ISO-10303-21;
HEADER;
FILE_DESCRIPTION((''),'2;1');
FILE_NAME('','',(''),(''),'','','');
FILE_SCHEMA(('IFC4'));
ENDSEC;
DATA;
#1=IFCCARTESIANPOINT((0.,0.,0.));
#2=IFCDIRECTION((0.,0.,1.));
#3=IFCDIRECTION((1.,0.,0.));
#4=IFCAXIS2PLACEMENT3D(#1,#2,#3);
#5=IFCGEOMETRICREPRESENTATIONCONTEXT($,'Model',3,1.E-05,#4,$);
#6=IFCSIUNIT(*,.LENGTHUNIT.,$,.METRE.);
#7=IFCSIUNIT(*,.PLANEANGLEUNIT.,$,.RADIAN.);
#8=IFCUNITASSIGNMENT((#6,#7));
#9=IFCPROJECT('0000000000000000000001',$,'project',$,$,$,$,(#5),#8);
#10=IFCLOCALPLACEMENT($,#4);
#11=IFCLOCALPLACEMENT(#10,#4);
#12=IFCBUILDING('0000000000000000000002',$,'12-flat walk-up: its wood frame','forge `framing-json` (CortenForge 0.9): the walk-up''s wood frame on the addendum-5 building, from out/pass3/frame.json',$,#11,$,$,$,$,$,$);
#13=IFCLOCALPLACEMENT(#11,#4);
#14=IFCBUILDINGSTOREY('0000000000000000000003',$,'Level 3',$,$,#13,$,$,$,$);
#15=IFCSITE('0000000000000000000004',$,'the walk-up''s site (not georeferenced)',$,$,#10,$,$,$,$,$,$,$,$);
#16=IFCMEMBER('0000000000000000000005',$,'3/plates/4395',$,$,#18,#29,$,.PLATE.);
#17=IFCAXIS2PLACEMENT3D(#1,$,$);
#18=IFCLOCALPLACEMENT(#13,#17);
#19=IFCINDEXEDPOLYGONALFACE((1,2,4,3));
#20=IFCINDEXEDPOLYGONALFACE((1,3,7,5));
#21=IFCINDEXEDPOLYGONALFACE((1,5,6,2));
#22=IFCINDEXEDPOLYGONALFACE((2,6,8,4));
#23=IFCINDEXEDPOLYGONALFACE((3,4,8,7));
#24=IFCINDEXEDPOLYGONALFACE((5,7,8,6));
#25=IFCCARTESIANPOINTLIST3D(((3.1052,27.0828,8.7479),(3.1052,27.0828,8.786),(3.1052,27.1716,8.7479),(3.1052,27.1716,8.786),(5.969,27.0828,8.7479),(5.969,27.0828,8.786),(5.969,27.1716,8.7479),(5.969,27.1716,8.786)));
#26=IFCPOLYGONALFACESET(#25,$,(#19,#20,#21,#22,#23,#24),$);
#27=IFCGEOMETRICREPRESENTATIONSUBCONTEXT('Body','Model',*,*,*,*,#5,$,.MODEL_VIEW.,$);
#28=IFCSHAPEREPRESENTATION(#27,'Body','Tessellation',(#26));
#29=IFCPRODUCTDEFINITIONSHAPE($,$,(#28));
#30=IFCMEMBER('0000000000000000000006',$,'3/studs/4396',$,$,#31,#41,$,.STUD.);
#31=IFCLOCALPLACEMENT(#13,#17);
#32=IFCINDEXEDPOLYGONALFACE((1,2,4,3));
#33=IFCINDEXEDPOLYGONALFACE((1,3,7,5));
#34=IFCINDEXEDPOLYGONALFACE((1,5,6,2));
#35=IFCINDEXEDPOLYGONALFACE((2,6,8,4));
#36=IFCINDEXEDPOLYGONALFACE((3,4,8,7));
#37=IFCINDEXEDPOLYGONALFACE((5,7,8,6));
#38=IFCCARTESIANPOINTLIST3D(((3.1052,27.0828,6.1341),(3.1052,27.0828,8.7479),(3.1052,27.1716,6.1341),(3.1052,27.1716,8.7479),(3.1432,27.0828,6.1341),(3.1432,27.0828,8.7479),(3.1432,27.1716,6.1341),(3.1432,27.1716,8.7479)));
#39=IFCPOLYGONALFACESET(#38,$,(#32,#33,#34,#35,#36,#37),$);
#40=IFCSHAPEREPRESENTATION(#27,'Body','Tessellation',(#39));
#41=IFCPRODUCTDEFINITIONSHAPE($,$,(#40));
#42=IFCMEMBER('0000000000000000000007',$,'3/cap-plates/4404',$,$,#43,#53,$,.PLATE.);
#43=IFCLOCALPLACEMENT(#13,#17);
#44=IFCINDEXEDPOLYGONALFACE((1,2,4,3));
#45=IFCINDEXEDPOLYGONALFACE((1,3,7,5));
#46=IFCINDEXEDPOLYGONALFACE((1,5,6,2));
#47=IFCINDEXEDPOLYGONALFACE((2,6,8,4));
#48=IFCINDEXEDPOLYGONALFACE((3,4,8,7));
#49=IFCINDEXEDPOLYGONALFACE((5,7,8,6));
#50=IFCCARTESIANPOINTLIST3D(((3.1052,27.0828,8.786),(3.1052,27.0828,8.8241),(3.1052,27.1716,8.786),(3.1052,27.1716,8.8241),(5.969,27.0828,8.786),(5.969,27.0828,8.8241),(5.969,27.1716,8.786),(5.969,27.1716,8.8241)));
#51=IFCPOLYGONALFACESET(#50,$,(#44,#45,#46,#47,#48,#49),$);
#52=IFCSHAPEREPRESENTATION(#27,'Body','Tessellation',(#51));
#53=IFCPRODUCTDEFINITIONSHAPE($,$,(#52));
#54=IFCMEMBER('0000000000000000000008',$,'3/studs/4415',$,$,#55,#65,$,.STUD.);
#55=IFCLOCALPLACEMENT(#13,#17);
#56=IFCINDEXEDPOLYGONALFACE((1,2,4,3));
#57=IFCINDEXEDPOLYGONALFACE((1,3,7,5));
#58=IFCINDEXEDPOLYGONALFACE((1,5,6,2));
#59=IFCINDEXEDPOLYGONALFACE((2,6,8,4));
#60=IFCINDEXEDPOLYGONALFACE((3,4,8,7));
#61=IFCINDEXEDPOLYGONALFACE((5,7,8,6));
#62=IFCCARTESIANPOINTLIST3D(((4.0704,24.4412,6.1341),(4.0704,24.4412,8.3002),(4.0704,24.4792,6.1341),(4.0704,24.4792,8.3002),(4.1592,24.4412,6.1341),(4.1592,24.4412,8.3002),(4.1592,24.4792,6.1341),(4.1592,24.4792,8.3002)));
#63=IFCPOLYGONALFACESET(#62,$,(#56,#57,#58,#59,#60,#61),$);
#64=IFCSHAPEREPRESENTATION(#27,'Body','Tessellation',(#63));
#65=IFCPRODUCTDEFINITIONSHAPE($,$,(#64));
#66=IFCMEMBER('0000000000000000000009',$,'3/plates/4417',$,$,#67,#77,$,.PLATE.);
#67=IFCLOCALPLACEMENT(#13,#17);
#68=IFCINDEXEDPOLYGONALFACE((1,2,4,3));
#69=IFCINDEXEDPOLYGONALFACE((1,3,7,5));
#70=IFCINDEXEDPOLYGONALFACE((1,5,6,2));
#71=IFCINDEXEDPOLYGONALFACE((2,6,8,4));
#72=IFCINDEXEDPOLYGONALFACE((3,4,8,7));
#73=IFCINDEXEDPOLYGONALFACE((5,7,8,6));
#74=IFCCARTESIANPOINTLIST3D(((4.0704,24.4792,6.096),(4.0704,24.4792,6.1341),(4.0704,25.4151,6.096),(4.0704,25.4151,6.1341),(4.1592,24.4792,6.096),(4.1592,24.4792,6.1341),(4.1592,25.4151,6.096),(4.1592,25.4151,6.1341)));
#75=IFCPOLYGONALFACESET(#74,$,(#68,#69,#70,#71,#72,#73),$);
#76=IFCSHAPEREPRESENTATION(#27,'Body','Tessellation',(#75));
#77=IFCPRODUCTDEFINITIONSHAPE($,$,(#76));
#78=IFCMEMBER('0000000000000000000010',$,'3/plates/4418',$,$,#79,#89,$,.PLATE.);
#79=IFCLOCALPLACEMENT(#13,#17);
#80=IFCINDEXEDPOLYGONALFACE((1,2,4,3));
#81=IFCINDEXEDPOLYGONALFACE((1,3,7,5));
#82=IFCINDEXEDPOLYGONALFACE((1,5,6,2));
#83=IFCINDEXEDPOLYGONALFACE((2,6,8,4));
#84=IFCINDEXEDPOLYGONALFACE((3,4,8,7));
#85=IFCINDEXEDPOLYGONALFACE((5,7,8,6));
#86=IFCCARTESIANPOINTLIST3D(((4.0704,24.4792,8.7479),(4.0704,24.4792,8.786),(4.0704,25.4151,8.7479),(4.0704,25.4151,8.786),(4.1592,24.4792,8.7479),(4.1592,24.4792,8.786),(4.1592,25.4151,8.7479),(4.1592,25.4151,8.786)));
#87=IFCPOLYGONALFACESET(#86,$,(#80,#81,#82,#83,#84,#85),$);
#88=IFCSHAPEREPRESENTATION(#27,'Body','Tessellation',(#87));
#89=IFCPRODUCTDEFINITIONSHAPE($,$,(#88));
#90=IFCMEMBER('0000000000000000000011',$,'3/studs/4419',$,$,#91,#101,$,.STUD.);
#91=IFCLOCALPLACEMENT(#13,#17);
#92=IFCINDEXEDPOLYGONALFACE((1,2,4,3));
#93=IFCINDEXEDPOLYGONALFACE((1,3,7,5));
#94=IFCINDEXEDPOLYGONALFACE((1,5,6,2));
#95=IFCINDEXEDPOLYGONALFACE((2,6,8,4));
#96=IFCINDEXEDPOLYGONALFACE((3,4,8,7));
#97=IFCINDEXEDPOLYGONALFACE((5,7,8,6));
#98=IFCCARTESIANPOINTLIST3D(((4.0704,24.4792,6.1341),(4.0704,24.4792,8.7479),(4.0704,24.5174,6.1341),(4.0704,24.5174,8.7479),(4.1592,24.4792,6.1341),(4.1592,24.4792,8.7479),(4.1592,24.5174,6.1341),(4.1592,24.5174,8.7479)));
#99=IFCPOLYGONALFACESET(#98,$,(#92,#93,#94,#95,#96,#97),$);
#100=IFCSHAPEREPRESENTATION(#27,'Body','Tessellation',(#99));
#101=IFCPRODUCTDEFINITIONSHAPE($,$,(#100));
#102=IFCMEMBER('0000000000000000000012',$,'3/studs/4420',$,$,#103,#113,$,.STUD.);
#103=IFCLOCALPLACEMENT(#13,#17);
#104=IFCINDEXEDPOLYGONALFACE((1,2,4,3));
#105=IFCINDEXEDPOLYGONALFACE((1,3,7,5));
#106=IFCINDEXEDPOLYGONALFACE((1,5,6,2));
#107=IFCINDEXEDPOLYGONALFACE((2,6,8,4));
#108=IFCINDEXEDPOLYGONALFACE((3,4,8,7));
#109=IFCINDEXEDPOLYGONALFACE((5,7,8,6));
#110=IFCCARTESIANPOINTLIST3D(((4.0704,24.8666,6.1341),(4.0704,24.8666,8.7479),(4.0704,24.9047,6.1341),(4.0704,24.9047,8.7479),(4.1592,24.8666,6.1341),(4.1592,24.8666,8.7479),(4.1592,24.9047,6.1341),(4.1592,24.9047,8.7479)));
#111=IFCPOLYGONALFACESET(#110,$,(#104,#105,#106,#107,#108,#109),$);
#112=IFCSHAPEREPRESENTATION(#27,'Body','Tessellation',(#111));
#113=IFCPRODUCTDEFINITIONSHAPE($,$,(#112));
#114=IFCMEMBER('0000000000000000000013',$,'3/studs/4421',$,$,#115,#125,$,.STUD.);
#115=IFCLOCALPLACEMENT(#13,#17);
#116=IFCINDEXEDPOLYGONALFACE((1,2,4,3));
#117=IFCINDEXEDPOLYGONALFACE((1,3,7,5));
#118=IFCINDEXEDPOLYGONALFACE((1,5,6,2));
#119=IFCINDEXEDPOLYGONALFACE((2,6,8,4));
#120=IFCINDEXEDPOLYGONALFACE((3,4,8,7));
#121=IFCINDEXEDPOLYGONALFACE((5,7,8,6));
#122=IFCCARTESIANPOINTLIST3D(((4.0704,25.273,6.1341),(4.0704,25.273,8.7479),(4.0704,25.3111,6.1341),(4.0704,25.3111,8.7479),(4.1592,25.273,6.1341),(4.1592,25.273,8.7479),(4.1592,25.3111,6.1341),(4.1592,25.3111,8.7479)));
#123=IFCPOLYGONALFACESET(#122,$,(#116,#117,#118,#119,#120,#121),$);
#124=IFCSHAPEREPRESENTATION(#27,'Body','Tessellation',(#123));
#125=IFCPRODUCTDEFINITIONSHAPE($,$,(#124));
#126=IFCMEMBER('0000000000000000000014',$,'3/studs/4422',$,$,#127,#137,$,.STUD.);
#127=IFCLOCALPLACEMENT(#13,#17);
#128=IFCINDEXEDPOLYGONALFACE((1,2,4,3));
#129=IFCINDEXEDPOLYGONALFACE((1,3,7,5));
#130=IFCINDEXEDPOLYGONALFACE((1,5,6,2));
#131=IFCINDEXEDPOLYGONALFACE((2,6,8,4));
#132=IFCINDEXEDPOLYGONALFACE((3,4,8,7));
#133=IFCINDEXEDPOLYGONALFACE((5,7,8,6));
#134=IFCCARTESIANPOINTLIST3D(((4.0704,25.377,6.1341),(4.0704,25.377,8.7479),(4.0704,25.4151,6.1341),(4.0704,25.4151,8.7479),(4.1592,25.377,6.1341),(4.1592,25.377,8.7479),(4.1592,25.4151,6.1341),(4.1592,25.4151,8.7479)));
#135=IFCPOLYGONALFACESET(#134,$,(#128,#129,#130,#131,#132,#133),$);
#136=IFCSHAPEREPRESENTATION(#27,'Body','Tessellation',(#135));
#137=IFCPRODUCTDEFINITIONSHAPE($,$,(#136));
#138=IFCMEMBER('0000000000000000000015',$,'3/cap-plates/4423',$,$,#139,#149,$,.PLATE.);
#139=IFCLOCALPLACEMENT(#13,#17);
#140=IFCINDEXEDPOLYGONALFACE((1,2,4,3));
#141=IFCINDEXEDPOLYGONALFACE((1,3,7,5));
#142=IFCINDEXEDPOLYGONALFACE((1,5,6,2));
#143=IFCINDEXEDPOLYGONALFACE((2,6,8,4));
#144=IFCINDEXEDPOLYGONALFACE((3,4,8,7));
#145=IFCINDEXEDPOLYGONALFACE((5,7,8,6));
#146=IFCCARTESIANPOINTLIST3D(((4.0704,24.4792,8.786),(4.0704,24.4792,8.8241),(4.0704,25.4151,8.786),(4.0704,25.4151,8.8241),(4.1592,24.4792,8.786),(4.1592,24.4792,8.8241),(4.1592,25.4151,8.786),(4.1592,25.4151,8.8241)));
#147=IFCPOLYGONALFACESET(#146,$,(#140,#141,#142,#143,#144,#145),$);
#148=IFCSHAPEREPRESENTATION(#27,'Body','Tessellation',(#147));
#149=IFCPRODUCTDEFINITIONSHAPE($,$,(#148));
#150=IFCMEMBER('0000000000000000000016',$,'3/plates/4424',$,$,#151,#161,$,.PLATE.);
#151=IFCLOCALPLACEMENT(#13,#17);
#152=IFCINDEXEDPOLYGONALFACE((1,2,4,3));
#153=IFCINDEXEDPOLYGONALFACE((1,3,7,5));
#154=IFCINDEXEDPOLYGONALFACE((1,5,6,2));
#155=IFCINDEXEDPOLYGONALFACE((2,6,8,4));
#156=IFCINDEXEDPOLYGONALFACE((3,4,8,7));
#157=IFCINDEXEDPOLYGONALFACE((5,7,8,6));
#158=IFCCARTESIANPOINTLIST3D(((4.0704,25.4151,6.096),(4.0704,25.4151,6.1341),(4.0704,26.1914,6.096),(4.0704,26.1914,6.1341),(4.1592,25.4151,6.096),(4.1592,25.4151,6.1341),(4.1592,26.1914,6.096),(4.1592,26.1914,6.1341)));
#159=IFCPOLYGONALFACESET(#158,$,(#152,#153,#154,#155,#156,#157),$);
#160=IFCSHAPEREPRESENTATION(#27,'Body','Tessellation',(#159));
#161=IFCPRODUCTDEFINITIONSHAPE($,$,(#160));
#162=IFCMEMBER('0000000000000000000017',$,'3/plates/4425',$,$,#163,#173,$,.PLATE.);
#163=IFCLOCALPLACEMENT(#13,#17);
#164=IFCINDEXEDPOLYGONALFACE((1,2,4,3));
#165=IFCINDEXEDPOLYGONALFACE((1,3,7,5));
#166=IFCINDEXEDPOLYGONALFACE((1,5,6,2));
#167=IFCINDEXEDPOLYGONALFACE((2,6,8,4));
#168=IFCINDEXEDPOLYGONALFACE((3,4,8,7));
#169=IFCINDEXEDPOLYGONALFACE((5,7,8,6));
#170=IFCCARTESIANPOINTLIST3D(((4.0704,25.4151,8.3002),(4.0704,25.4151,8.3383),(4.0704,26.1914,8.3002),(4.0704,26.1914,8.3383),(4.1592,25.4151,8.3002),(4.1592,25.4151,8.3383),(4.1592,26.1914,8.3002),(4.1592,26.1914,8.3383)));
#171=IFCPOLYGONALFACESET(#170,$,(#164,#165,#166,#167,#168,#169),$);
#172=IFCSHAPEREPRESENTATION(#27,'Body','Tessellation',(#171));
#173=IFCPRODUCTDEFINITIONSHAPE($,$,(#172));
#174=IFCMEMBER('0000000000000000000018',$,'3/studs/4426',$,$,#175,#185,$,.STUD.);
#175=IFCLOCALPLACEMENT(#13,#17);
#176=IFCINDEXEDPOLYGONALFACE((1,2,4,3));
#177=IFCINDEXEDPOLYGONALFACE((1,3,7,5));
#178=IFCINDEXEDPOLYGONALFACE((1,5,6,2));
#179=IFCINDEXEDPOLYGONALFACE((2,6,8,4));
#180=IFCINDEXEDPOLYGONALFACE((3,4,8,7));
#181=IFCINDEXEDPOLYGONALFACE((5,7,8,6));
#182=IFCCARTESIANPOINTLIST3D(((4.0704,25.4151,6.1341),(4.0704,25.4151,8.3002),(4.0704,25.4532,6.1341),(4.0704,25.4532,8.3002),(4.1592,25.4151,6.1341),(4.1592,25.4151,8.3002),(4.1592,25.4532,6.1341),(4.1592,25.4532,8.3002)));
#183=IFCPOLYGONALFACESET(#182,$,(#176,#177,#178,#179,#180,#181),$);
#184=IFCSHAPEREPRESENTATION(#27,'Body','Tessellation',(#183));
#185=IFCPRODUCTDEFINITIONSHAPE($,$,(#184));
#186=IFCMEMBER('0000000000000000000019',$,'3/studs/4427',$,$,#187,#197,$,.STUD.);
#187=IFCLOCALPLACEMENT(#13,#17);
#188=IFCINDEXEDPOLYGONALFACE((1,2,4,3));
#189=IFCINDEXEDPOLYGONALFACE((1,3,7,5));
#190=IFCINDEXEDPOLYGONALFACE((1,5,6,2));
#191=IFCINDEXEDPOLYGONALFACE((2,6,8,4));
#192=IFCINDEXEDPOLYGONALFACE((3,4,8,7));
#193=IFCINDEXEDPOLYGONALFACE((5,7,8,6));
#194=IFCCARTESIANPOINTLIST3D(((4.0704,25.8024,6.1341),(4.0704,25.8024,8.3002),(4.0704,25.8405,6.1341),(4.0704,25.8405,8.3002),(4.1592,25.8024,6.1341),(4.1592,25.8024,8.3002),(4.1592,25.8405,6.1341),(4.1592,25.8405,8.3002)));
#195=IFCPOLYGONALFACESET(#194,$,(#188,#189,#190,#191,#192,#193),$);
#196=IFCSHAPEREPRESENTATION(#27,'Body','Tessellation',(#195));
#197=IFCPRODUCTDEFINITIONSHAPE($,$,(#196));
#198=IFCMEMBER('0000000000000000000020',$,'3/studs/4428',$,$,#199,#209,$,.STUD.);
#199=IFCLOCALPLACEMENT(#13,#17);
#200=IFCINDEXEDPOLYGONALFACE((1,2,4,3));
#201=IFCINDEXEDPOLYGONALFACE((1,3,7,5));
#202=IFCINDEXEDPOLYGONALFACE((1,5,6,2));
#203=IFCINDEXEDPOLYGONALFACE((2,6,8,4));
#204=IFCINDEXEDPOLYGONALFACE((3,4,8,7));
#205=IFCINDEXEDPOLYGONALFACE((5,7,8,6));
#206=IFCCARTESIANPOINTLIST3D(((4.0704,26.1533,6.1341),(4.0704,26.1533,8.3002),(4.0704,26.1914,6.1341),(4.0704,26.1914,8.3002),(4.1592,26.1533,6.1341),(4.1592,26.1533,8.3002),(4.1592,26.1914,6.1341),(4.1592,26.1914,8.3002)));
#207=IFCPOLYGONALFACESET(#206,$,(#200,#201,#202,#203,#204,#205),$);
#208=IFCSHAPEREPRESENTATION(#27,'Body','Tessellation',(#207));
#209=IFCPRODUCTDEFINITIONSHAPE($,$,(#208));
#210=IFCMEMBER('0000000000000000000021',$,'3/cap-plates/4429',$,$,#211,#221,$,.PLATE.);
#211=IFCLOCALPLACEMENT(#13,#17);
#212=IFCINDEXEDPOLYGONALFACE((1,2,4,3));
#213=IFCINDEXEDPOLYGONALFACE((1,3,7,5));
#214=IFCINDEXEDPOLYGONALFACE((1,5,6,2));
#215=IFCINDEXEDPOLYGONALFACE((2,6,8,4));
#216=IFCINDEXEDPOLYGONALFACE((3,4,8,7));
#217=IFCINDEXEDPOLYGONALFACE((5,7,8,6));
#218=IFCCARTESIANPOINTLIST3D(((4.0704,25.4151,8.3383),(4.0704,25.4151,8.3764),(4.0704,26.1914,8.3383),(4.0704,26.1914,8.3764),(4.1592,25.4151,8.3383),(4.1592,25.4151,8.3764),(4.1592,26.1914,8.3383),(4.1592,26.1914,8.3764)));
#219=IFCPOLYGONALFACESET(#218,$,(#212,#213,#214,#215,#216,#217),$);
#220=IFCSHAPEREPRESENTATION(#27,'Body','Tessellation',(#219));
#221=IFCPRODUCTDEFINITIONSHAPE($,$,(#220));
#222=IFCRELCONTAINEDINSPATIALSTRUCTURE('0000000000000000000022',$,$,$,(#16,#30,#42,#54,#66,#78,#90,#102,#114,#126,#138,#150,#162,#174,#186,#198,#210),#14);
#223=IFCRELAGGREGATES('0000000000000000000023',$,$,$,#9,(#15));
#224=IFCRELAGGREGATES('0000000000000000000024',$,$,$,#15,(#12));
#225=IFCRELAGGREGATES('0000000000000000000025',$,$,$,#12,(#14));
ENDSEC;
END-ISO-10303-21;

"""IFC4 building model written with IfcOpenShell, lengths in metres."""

from ifc_helpers import new_model, si_unit, frame, frame_2d, origin, origin_with_axes, place, context, subcontext, project, spatial, rectangle, extrude, element, save


model = new_model("IFC4")

# Units and contexts
model_context = context("Model", 3, precision=1e-05, world=origin_with_axes())
body_context = subcontext(model_context, "Body", "Model", "MODEL_VIEW")
ifc_project = project(units=[si_unit("LENGTHUNIT", "METRE"), si_unit("PLANEANGLEUNIT", "RADIAN")], contexts=[model_context])

# Site, building, storey
site_placement = place(None, origin_with_axes())
site = spatial("IfcSite", under=ifc_project, at=site_placement, Name="the walk-up's site (not georeferenced)")
building_placement = place(site_placement, origin_with_axes())
building = spatial("IfcBuilding", under=site, at=building_placement, Name="12-flat walk-up: its wood frame", Description="forge `framing-json` (CortenForge 0.9): the walk-up's wood frame on the addendum-5 building, from out/pass3/frame.json")
storey_placement = place(building_placement, origin_with_axes())
storey = spatial("IfcBuildingStorey", under=building, at=storey_placement, Name="Level 3")

# Members
member_1_placement = place(storey_placement, frame((3.1052, 27.0828, 8.7479), z_axis=(0.0, 0.0, 1.0), x_axis=(1.0, 0.0, 0.0)))
element("IfcMember", 1, at=member_1_placement, inside=storey, Name="3/plates/4395", PredefinedType="PLATE", context=body_context, shape_type="SweptSolid", body=[
    extrude(rectangle(XDim=2.8639, YDim=0.0889, at=frame_2d((1.4319, 0.0444))), origin(), (0.0, 0.0, 1.0), 0.0381),
])
member_2_placement = place(storey_placement, frame((3.1052, 27.0828, 6.1341), z_axis=(0.0, 0.0, 1.0), x_axis=(1.0, 0.0, 0.0)))
element("IfcMember", 2, at=member_2_placement, inside=storey, Name="3/studs/4396", PredefinedType="STUD", context=body_context, shape_type="SweptSolid", body=[
    extrude(rectangle(XDim=0.0381, YDim=0.0889, at=frame_2d((0.0191, 0.0444))), origin(), (0.0, 0.0, 1.0), 2.6138),
])
member_3_placement = place(storey_placement, frame((3.1052, 27.0828, 8.786), z_axis=(0.0, 0.0, 1.0), x_axis=(1.0, 0.0, 0.0)))
element("IfcMember", 3, at=member_3_placement, inside=storey, Name="3/cap-plates/4404", PredefinedType="PLATE", context=body_context, shape_type="SweptSolid", body=[
    extrude(rectangle(XDim=2.8639, YDim=0.0889, at=frame_2d((1.4319, 0.0444))), origin(), (0.0, 0.0, 1.0), 0.0381),
])
member_4_placement = place(storey_placement, frame((4.0704, 24.4412, 6.1341), z_axis=(0.0, 0.0, 1.0), x_axis=(1.0, 0.0, 0.0)))
element("IfcMember", 4, at=member_4_placement, inside=storey, Name="3/studs/4415", PredefinedType="STUD", context=body_context, shape_type="SweptSolid", body=[
    extrude(rectangle(XDim=0.0889, YDim=0.0381, at=frame_2d((0.0444, 0.0191))), origin(), (0.0, 0.0, 1.0), 2.1661),
])
for number, where, z_axis, x_axis, name in (
    (5, (4.0704, 24.4793, 6.096), (0.0, 0.0, 1.0), (1.0, 0.0, 0.0), "3/plates/4417"),
    (6, (4.0704, 24.4793, 8.7479), (0.0, 0.0, 1.0), (1.0, 0.0, 0.0), "3/plates/4418"),
):
    element("IfcMember", number, at=place(storey_placement, frame(where, z_axis=z_axis, x_axis=x_axis)), inside=storey, Name=name, PredefinedType="PLATE", context=body_context, shape_type="SweptSolid", body=[
        extrude(rectangle(XDim=0.0889, YDim=0.9358, at=frame_2d((0.0444, 0.4679))), origin(), (0.0, 0.0, 1.0), 0.0381),
    ])
for number, where, z_axis, x_axis, name in (
    (7, (4.0704, 24.4793, 6.1341), (0.0, 0.0, 1.0), (1.0, 0.0, 0.0), "3/studs/4419"),
    (8, (4.0704, 24.8666, 6.1341), (0.0, 0.0, 1.0), (1.0, 0.0, 0.0), "3/studs/4420"),
    (9, (4.0704, 25.273, 6.1341), (0.0, 0.0, 1.0), (1.0, 0.0, 0.0), "3/studs/4421"),
    (10, (4.0704, 25.377, 6.1341), (0.0, 0.0, 1.0), (1.0, 0.0, 0.0), "3/studs/4422"),
):
    element("IfcMember", number, at=place(storey_placement, frame(where, z_axis=z_axis, x_axis=x_axis)), inside=storey, Name=name, PredefinedType="STUD", context=body_context, shape_type="SweptSolid", body=[
        extrude(rectangle(XDim=0.0889, YDim=0.0381, at=frame_2d((0.0444, 0.0191))), origin(), (0.0, 0.0, 1.0), 2.6138),
    ])
member_5_placement = place(storey_placement, frame((4.0704, 24.4793, 8.786), z_axis=(0.0, 0.0, 1.0), x_axis=(1.0, 0.0, 0.0)))
element("IfcMember", 11, at=member_5_placement, inside=storey, Name="3/cap-plates/4423", PredefinedType="PLATE", context=body_context, shape_type="SweptSolid", body=[
    extrude(rectangle(XDim=0.0889, YDim=0.9358, at=frame_2d((0.0444, 0.4679))), origin(), (0.0, 0.0, 1.0), 0.0381),
])
for number, where, z_axis, x_axis, name in (
    (12, (4.0704, 25.4151, 6.096), (0.0, 0.0, 1.0), (1.0, 0.0, 0.0), "3/plates/4424"),
    (13, (4.0704, 25.4151, 8.3002), (0.0, 0.0, 1.0), (1.0, 0.0, 0.0), "3/plates/4425"),
):
    element("IfcMember", number, at=place(storey_placement, frame(where, z_axis=z_axis, x_axis=x_axis)), inside=storey, Name=name, PredefinedType="PLATE", context=body_context, shape_type="SweptSolid", body=[
        extrude(rectangle(XDim=0.0889, YDim=0.7763, at=frame_2d((0.0444, 0.3881))), origin(), (0.0, 0.0, 1.0), 0.0381),
    ])
for number, where, z_axis, x_axis, name in (
    (14, (4.0704, 25.4151, 6.1341), (0.0, 0.0, 1.0), (1.0, 0.0, 0.0), "3/studs/4426"),
    (15, (4.0704, 25.8024, 6.1341), (0.0, 0.0, 1.0), (1.0, 0.0, 0.0), "3/studs/4427"),
    (16, (4.0704, 26.1533, 6.1341), (0.0, 0.0, 1.0), (1.0, 0.0, 0.0), "3/studs/4428"),
):
    element("IfcMember", number, at=place(storey_placement, frame(where, z_axis=z_axis, x_axis=x_axis)), inside=storey, Name=name, PredefinedType="STUD", context=body_context, shape_type="SweptSolid", body=[
        extrude(rectangle(XDim=0.0889, YDim=0.0381, at=frame_2d((0.0444, 0.0191))), origin(), (0.0, 0.0, 1.0), 2.1661),
    ])
member_6_placement = place(storey_placement, frame((4.0704, 25.4151, 8.3383), z_axis=(0.0, 0.0, 1.0), x_axis=(1.0, 0.0, 0.0)))
element("IfcMember", 17, at=member_6_placement, inside=storey, Name="3/cap-plates/4429", PredefinedType="PLATE", context=body_context, shape_type="SweptSolid", body=[
    extrude(rectangle(XDim=0.0889, YDim=0.7763, at=frame_2d((0.0444, 0.3881))), origin(), (0.0, 0.0, 1.0), 0.0381),
])

save(model, "model.ifc")
